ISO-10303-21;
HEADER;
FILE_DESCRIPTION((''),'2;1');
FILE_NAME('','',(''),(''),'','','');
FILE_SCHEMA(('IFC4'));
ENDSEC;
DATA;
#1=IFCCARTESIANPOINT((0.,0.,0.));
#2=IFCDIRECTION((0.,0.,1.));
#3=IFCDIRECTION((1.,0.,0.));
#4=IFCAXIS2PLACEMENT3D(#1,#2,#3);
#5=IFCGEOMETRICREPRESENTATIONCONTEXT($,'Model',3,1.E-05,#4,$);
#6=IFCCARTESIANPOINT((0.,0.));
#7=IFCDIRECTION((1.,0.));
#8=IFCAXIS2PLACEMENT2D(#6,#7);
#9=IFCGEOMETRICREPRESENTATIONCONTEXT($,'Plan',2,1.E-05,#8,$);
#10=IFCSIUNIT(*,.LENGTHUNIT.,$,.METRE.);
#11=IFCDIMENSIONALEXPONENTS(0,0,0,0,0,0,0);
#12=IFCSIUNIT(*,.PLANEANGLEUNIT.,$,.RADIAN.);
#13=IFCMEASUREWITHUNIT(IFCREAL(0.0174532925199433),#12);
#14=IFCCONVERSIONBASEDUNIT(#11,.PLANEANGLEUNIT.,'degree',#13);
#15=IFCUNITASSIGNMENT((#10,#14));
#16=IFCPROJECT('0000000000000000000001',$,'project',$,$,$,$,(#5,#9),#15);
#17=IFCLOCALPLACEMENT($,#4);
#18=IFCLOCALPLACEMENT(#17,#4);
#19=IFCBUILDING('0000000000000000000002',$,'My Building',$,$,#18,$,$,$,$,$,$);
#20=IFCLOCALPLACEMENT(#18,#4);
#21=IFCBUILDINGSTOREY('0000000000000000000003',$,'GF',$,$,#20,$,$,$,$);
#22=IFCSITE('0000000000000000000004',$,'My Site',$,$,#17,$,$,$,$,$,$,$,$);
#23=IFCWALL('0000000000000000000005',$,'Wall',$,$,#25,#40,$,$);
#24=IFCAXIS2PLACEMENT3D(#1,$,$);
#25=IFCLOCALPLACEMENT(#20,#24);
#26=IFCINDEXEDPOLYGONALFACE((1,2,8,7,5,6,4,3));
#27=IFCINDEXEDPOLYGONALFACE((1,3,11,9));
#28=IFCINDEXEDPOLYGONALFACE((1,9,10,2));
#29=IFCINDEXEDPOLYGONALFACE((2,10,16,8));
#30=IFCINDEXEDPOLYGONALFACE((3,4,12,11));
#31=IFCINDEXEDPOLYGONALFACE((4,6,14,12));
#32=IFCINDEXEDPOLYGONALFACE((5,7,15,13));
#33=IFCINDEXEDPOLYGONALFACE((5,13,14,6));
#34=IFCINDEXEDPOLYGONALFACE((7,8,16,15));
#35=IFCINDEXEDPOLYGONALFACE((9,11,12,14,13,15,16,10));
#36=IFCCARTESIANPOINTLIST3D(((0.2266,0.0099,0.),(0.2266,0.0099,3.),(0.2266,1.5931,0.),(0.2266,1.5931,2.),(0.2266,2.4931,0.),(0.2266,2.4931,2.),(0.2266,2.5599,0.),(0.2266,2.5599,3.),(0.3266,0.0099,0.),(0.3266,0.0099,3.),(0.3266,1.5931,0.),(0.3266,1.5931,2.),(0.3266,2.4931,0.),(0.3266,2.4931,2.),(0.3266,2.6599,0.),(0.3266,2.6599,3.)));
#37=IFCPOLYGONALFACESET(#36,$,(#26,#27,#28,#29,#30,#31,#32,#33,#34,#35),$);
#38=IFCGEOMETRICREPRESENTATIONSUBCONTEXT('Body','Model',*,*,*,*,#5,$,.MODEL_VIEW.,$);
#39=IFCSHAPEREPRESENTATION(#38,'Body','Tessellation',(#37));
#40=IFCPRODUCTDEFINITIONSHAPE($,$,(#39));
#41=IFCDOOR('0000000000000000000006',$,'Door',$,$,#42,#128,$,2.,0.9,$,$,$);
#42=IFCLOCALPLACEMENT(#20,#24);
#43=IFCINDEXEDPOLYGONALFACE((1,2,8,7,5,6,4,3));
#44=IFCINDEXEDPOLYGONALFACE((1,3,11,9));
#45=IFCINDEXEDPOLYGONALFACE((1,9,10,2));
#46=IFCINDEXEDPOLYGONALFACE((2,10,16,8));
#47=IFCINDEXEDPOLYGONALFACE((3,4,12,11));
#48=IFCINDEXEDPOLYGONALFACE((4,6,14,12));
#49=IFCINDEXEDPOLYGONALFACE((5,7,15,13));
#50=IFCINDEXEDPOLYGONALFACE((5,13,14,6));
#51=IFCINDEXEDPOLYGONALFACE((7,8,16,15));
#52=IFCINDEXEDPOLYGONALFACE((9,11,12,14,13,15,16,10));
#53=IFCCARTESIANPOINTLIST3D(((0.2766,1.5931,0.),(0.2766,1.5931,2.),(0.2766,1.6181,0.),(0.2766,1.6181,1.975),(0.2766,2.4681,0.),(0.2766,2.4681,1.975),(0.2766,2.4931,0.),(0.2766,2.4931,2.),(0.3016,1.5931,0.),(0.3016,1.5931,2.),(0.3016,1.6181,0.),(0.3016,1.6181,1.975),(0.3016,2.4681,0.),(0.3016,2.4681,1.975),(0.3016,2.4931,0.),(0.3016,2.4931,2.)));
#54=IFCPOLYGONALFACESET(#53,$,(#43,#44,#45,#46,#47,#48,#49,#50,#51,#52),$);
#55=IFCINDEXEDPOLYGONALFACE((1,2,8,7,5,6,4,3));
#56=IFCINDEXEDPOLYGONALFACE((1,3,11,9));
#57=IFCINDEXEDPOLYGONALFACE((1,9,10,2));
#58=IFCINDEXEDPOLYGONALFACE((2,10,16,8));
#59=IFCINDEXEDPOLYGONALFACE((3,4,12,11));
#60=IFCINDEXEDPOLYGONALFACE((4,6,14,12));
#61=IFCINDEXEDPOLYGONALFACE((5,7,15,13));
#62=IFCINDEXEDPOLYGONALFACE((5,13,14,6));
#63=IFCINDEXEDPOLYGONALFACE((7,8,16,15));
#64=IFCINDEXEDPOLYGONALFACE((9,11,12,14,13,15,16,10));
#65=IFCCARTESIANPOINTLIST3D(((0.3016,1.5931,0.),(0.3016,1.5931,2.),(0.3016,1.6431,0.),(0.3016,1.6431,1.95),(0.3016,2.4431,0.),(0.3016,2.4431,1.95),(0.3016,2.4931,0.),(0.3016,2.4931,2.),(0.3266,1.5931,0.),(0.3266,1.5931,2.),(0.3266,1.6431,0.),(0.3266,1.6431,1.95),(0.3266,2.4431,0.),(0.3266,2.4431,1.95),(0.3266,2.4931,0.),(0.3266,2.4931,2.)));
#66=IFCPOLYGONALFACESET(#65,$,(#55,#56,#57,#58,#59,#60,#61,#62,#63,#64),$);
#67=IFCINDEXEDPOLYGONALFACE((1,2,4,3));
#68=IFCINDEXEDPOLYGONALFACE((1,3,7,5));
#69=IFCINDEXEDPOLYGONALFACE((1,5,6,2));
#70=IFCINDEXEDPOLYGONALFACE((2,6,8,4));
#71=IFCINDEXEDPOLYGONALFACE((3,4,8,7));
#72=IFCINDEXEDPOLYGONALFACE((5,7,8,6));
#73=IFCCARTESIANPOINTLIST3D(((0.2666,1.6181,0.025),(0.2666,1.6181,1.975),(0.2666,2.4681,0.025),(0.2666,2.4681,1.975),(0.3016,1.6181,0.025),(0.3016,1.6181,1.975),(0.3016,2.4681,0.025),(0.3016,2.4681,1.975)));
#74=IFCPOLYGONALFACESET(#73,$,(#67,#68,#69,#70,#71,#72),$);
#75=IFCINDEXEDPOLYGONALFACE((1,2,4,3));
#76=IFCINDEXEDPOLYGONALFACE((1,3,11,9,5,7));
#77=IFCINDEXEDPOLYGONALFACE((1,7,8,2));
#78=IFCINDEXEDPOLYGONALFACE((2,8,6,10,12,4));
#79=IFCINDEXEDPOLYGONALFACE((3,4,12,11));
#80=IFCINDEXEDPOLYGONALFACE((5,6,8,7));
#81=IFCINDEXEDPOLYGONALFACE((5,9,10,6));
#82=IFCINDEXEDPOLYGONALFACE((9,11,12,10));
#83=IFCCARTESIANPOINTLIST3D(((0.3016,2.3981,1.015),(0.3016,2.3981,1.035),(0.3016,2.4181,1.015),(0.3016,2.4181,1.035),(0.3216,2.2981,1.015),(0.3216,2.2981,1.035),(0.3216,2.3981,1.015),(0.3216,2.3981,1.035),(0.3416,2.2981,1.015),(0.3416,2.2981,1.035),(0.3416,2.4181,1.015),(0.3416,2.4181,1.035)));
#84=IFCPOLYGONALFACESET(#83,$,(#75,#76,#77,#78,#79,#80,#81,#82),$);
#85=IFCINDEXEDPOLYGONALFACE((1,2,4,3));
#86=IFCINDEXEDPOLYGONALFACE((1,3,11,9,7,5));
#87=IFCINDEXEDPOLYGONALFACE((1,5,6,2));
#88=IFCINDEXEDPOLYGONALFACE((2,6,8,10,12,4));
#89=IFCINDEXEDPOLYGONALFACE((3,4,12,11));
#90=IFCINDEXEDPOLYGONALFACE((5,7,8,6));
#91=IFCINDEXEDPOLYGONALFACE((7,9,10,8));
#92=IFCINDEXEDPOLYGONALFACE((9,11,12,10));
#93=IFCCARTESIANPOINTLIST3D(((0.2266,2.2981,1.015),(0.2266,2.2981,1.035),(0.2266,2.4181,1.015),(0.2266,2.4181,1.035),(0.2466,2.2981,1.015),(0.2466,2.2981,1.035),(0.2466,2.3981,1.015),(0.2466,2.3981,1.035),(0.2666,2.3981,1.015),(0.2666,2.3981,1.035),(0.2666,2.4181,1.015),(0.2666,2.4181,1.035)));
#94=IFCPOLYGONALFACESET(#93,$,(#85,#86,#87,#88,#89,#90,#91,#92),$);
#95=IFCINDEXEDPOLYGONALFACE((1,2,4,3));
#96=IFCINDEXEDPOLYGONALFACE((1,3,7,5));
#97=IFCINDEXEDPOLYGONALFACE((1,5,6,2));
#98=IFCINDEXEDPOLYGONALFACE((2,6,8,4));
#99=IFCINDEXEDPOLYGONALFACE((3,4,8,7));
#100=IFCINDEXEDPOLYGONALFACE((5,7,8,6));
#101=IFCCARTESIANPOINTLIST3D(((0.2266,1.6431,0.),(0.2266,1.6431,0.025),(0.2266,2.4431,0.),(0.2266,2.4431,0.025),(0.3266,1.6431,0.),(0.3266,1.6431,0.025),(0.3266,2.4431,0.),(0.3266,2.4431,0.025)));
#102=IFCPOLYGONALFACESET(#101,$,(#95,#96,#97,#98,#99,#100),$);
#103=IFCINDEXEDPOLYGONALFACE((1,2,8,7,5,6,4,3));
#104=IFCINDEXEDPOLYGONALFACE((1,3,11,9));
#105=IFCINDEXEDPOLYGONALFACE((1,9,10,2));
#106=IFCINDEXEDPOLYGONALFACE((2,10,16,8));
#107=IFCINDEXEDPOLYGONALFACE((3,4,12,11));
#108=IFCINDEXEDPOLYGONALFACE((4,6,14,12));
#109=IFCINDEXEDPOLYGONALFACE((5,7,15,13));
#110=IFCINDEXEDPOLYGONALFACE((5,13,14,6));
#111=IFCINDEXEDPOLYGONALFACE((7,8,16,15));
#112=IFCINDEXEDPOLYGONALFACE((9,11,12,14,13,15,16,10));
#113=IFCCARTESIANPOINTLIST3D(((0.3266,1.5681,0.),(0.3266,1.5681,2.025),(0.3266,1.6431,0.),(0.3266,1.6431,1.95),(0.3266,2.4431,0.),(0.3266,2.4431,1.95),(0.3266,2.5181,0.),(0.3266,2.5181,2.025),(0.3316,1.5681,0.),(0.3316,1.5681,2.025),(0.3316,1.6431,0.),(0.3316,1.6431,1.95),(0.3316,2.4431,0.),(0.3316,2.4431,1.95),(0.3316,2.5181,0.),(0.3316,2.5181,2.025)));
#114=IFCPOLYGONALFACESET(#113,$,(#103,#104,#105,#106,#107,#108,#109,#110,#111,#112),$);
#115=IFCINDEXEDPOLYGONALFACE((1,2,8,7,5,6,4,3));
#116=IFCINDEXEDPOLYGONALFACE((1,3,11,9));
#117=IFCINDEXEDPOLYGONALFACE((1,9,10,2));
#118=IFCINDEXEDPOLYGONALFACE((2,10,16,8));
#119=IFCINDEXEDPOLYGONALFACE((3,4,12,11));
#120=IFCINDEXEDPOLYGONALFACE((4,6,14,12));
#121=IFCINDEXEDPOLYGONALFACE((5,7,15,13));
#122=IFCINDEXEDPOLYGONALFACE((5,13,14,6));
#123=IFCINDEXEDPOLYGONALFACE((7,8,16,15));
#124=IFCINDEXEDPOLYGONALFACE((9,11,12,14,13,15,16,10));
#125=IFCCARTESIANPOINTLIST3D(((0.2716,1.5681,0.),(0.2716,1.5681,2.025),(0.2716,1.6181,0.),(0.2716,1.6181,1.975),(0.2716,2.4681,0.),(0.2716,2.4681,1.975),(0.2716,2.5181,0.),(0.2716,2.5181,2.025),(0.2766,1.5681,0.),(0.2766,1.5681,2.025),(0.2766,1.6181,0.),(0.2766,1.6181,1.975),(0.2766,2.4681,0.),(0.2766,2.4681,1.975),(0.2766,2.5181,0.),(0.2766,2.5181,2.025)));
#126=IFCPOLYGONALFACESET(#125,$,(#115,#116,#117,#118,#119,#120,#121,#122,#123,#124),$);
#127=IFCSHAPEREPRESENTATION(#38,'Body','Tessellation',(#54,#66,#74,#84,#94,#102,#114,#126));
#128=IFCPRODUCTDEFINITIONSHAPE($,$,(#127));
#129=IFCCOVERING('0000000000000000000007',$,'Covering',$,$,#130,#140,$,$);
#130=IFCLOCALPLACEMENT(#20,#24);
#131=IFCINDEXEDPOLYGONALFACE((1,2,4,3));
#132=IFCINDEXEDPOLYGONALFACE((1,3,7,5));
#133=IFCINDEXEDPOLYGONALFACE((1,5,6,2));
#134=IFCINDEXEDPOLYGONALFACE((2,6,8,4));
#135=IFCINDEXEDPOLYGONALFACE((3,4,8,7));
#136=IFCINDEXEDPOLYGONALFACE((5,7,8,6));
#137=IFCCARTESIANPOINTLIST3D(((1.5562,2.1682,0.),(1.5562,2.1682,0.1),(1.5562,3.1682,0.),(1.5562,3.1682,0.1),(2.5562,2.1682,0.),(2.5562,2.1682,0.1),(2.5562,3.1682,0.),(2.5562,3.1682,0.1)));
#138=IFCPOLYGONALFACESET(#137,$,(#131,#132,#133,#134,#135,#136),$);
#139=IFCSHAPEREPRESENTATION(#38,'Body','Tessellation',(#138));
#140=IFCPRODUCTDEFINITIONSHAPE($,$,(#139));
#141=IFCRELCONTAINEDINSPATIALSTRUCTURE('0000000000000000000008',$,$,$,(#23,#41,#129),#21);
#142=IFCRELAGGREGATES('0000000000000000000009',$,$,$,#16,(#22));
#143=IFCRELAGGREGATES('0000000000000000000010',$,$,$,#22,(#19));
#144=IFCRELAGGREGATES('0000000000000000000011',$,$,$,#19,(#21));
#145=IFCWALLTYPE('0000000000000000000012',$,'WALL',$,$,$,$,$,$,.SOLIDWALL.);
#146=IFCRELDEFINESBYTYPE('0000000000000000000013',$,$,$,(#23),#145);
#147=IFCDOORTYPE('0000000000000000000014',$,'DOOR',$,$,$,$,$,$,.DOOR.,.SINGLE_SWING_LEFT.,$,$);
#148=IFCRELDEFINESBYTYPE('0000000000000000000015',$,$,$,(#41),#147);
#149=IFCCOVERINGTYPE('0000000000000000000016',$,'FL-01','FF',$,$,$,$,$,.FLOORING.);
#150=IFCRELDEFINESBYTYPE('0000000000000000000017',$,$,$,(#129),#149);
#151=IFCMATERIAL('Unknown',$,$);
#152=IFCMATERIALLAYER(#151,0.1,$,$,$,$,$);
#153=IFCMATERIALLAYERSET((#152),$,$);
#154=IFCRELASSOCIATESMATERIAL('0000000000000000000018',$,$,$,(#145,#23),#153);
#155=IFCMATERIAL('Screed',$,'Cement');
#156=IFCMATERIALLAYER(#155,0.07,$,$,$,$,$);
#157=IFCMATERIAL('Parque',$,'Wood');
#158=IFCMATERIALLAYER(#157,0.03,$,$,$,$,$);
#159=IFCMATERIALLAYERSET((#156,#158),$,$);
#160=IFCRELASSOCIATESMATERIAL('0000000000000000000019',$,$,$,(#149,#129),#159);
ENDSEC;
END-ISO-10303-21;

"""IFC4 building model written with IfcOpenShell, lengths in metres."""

from ifc_helpers import new_model, entity, si_unit, converted_unit, frame, origin_with_axes, origin_2d_with_axis, place, context, subcontext, project, spatial, line, indexed_curve, outline, extrude, shape, source, transform, mapped, material, layer, layer_set, layer_usage, type_object, type_shapes, element, fill, save


model = new_model("IFC4")

# Units and contexts
model_context = context("Model", 3, precision=1e-05, world=origin_with_axes())
plan_context = context("Plan", 2, precision=1e-05, world=origin_2d_with_axis())
body_context_1 = subcontext(model_context, "Body", "Model", "MODEL_VIEW")
body_context_2 = subcontext(plan_context, "Body", "Plan", "PLAN_VIEW")
ifc_project = project(units=[si_unit("LENGTHUNIT", "METRE"), converted_unit("PLANEANGLEUNIT", "degree", entity("IfcReal", 0.0174532925199433), si_unit("PLANEANGLEUNIT", "RADIAN"), dimensions=[0, 0, 0, 0, 0, 0, 0])], contexts=[model_context, plan_context])

# Site, building, storey
site_placement = place(None, origin_with_axes())
site = spatial("IfcSite", under=ifc_project, at=site_placement, Name="My Site")
building_placement = place(site_placement, origin_with_axes())
building = spatial("IfcBuilding", under=site, at=building_placement, Name="My Building")
storey_placement = place(building_placement, origin_with_axes())
storey = spatial("IfcBuildingStorey", under=building, at=storey_placement, Name="GF")

# Shared definitions
ifc_material_1 = material(Name="Unknown")

# Shared definitions
ifc_layer_1 = layer(ifc_material_1, 0.1)
ifc_layer_set_1 = layer_set([ifc_layer_1])
wall_type = type_object("IfcWallType", Name="WALL", PredefinedType="SOLIDWALL", material=ifc_layer_set_1)
shared_shape_1 = source(origin_with_axes(), body_context_1, "Body", "SweptSolid", [
    extrude(outline(indexed_curve([(0.0, 0.0), (0.9, 0.0), (0.9, 2.0), (0.0, 2.0)], segments=[line(1, 2, 3, 4, 1)])), frame((0.0, -0.6, 0.0), z_axis=(0.0, -1.0, 0.0), x_axis=(1.0, 0.0, 0.0)), (0.0, 0.0, -1.0), 1.2),
])
door_type = type_object("IfcDoorType", Name="DOOR", OperationType="SINGLE_SWING_LEFT", PredefinedType="DOOR")
shared_shape_2 = source(origin_with_axes(), body_context_1, "Body", "SweptSolid", [
    extrude(outline(indexed_curve([(0.0, 0.0), (0.0, 2.0), (0.9, 2.0), (0.9, 0.0), (0.875, 0.0), (0.875, 1.975), (0.025, 1.975), (0.025, 0.0)], segments=[line(1, 2, 3, 4, 5, 6, 7, 8, 1)])), frame((0.0, 0.025, 0.0), z_axis=(0.0, -1.0, 0.0), x_axis=(1.0, 0.0, 0.0)), (0.0, 0.0, -1.0), 0.025),
    extrude(outline(indexed_curve([(0.0, 0.0), (0.0, 2.0), (0.9, 2.0), (0.9, 0.0), (0.85, 0.0), (0.85, 1.95), (0.05, 1.95), (0.05, 0.0)], segments=[line(1, 2, 3, 4, 5, 6, 7, 8, 1)])), frame((0.0, 0.0, 0.0), z_axis=(0.0, -1.0, 0.0), x_axis=(1.0, 0.0, 0.0)), (0.0, 0.0, -1.0), 0.025),
    extrude(outline(indexed_curve([(0.0, 0.0), (0.85, 0.0), (0.85, 0.035), (0.0, 0.035)], segments=[line(1, 2, 3, 4, 1)])), frame((0.025, 0.025, 0.025), z_axis=(0.0, 0.0, 1.0), x_axis=(1.0, 0.0, 0.0)), (0.0, 0.0, 1.0), 1.95),
    extrude(outline(indexed_curve([(0.0, 0.0), (0.0, -0.04), (-0.12, -0.04), (-0.12, -0.02), (-0.02, -0.02), (-0.02, 0.0)], segments=[line(1, 2, 3, 4, 5, 6, 1)])), frame((0.825, 0.025, 1.015), z_axis=(0.0, 0.0, 1.0), x_axis=(1.0, 0.0, 0.0)), (0.0, 0.0, 1.0), 0.02),
    extrude(outline(indexed_curve([(0.0, 0.0), (0.0, 0.04), (-0.12, 0.04), (-0.12, 0.02), (-0.02, 0.02), (-0.02, 0.0)], segments=[line(1, 2, 3, 4, 5, 6, 1)])), frame((0.825, 0.06, 1.015), z_axis=(0.0, 0.0, 1.0), x_axis=(1.0, 0.0, 0.0)), (0.0, 0.0, 1.0), 0.02),
    extrude(outline(indexed_curve([(0.0, 0.0), (0.8, 0.0), (0.8, 0.1), (0.0, 0.1)], segments=[line(1, 2, 3, 4, 1)])), frame((0.05, 0.0, 0.0), z_axis=(0.0, 0.0, 1.0), x_axis=(1.0, 0.0, 0.0)), (0.0, 0.0, 1.0), 0.025),
    extrude(outline(indexed_curve([(0.0, 0.0), (0.0, 2.025), (0.95, 2.025), (0.95, 0.0), (0.875, 0.0), (0.875, 1.95), (0.075, 1.95), (0.075, 0.0)], segments=[line(1, 2, 3, 4, 5, 6, 7, 8, 1)])), frame((-0.025, -0.005, 0.0), z_axis=(0.0, -1.0, 0.0), x_axis=(1.0, 0.0, 0.0)), (0.0, 0.0, -1.0), 0.005),
    extrude(outline(indexed_curve([(0.0, 0.0), (0.0, 2.025), (0.95, 2.025), (0.95, 0.0), (0.9, 0.0), (0.9, 1.975), (0.05, 1.975), (0.05, 0.0)], segments=[line(1, 2, 3, 4, 5, 6, 7, 8, 1)])), frame((-0.025, 0.05, 0.0), z_axis=(0.0, -1.0, 0.0), x_axis=(1.0, 0.0, 0.0)), (0.0, 0.0, -1.0), 0.005),
])
shared_shape_3 = source(origin_with_axes(), body_context_2, "Body", "Curve2D", [
    entity("IfcIndexedPolyCurve", entity("IfcCartesianPointList2D", [[0.0, 0.0], [0.0, 0.05], [0.025, 0.05], [0.025, 0.025], [0.05, 0.025], [0.05, 0.0]]), [entity("IfcLineIndex", [1, 2, 3, 4, 5, 6, 1])]),
    entity("IfcIndexedPolyCurve", entity("IfcCartesianPointList2D", [[0.9, 0.0], [0.9, 0.05], [0.875, 0.05], [0.875, 0.025], [0.85, 0.025], [0.85, 0.0]]), [entity("IfcLineIndex", [1, 2, 3, 4, 5, 6, 1])]),
    entity("IfcTrimmedCurve", entity("IfcEllipse", entity("IfcAxis2Placement2D", entity("IfcCartesianPoint", [0.06, 0.05]), entity("IfcDirection", [1.0, 0.0])), 0.815, 0.85), [entity("IfcCartesianPoint", [0.875, 0.05])], [entity("IfcCartesianPoint", [0.06, 0.9])], True, "CARTESIAN"),
    entity("IfcIndexedPolyCurve", entity("IfcCartesianPointList2D", [[0.025, 0.05], [0.06, 0.05], [0.06, 0.9], [0.025, 0.9]]), [entity("IfcLineIndex", [1, 2, 3, 4, 1])]),
])
type_shapes(door_type, [shared_shape_2, shared_shape_3])

# Wall, opening, door
ifc_layer_usage_1 = layer_usage(ifc_layer_set_1, "AXIS2", "POSITIVE", 0.0)
wall_1_placement = place(storey_placement, frame((0.3266, 0.0099, 0.0), z_axis=(0.0, 0.0, 1.0), x_axis=(0.0, 1.0, 0.0)))
wall_1 = element("IfcWall", 1, at=wall_1_placement, inside=storey, type_object=wall_type, material=ifc_layer_usage_1, Name="Wall", context=body_context_1, shape_type="SweptSolid", body=[
    extrude(outline(indexed_curve([(0.0, 0.0), (0.0, 0.1), (2.55, 0.1), (2.65, 0.0)], segments=[line(1, 2, 3, 4, 1)])), origin_with_axes(), (0.0, 0.0, 1.0), 3.0),
])
opening_1_placement = place(wall_1_placement, frame((1.5832, 0.0, 0.0), z_axis=(0.0, 0.0, 1.0), x_axis=(1.0, 0.0, 0.0)))
opening_1 = element("IfcOpeningElement", 2, at=opening_1_placement, cuts=wall_1, PredefinedType="OPENING", context=body_context_1, shape_type="MappedRepresentation", body=[
    mapped(shared_shape_1, transform((0.0, 0.0, 0.0), x_axis=(1.0, 0.0, 0.0), y_axis=(0.0, 1.0, 0.0), z_axis=(0.0, 0.0, 1.0), scale=1.0)),
])
door_1_placement = place(opening_1_placement, frame((0.0, 0.0, 0.0), z_axis=(0.0, 0.0, 1.0), x_axis=(1.0, 0.0, 0.0)))
door_1 = element("IfcDoor", 3, at=door_1_placement, inside=storey, type_object=door_type, Name="Door", OverallHeight=2.0, OverallWidth=0.9, shapes=[
    shape(body_context_1, "Body", "MappedRepresentation", [mapped(shared_shape_2, transform((0.0, 0.0, 0.0), x_axis=(1.0, 0.0, 0.0), y_axis=(0.0, 1.0, 0.0), z_axis=(0.0, 0.0, 1.0), scale=1.0))]),
    shape(body_context_2, "Body", "MappedRepresentation", [mapped(shared_shape_3, transform((0.0, 0.0, 0.0), x_axis=(1.0, 0.0, 0.0), y_axis=(0.0, 1.0, 0.0), z_axis=(0.0, 0.0, 1.0), scale=1.0))]),
])
fill(opening_1, door_1)

# Covering
ifc_material_2 = material(Name="Screed", Category="Cement")
ifc_layer_2 = layer(ifc_material_2, 0.07)
ifc_material_3 = material(Name="Parque", Category="Wood")
ifc_layer_3 = layer(ifc_material_3, 0.03)
ifc_layer_set_2 = layer_set([ifc_layer_2, ifc_layer_3])
ifc_layer_usage_2 = layer_usage(ifc_layer_set_2, "AXIS3", "POSITIVE", 0.0)
covering_type = type_object("IfcCoveringType", Name="FL-01", Description="FF", PredefinedType="FLOORING", material=ifc_layer_set_2)
covering_placement = place(storey_placement, frame((1.5562, 2.1682, 0.0), z_axis=(0.0, 0.0, 1.0), x_axis=(1.0, 0.0, 0.0)))
element("IfcCovering", 4, at=covering_placement, inside=storey, type_object=covering_type, material=ifc_layer_usage_2, Name="Covering", context=body_context_1, shape_type="SweptSolid", body=[
    extrude(outline(indexed_curve([(0.0, 0.0), (1.0, 0.0), (1.0, 1.0), (0.0, 1.0), (0.0, 0.0)])), None, (0.0, 0.0, 1.0), 0.1),
])

save(model, "model.ifc")
